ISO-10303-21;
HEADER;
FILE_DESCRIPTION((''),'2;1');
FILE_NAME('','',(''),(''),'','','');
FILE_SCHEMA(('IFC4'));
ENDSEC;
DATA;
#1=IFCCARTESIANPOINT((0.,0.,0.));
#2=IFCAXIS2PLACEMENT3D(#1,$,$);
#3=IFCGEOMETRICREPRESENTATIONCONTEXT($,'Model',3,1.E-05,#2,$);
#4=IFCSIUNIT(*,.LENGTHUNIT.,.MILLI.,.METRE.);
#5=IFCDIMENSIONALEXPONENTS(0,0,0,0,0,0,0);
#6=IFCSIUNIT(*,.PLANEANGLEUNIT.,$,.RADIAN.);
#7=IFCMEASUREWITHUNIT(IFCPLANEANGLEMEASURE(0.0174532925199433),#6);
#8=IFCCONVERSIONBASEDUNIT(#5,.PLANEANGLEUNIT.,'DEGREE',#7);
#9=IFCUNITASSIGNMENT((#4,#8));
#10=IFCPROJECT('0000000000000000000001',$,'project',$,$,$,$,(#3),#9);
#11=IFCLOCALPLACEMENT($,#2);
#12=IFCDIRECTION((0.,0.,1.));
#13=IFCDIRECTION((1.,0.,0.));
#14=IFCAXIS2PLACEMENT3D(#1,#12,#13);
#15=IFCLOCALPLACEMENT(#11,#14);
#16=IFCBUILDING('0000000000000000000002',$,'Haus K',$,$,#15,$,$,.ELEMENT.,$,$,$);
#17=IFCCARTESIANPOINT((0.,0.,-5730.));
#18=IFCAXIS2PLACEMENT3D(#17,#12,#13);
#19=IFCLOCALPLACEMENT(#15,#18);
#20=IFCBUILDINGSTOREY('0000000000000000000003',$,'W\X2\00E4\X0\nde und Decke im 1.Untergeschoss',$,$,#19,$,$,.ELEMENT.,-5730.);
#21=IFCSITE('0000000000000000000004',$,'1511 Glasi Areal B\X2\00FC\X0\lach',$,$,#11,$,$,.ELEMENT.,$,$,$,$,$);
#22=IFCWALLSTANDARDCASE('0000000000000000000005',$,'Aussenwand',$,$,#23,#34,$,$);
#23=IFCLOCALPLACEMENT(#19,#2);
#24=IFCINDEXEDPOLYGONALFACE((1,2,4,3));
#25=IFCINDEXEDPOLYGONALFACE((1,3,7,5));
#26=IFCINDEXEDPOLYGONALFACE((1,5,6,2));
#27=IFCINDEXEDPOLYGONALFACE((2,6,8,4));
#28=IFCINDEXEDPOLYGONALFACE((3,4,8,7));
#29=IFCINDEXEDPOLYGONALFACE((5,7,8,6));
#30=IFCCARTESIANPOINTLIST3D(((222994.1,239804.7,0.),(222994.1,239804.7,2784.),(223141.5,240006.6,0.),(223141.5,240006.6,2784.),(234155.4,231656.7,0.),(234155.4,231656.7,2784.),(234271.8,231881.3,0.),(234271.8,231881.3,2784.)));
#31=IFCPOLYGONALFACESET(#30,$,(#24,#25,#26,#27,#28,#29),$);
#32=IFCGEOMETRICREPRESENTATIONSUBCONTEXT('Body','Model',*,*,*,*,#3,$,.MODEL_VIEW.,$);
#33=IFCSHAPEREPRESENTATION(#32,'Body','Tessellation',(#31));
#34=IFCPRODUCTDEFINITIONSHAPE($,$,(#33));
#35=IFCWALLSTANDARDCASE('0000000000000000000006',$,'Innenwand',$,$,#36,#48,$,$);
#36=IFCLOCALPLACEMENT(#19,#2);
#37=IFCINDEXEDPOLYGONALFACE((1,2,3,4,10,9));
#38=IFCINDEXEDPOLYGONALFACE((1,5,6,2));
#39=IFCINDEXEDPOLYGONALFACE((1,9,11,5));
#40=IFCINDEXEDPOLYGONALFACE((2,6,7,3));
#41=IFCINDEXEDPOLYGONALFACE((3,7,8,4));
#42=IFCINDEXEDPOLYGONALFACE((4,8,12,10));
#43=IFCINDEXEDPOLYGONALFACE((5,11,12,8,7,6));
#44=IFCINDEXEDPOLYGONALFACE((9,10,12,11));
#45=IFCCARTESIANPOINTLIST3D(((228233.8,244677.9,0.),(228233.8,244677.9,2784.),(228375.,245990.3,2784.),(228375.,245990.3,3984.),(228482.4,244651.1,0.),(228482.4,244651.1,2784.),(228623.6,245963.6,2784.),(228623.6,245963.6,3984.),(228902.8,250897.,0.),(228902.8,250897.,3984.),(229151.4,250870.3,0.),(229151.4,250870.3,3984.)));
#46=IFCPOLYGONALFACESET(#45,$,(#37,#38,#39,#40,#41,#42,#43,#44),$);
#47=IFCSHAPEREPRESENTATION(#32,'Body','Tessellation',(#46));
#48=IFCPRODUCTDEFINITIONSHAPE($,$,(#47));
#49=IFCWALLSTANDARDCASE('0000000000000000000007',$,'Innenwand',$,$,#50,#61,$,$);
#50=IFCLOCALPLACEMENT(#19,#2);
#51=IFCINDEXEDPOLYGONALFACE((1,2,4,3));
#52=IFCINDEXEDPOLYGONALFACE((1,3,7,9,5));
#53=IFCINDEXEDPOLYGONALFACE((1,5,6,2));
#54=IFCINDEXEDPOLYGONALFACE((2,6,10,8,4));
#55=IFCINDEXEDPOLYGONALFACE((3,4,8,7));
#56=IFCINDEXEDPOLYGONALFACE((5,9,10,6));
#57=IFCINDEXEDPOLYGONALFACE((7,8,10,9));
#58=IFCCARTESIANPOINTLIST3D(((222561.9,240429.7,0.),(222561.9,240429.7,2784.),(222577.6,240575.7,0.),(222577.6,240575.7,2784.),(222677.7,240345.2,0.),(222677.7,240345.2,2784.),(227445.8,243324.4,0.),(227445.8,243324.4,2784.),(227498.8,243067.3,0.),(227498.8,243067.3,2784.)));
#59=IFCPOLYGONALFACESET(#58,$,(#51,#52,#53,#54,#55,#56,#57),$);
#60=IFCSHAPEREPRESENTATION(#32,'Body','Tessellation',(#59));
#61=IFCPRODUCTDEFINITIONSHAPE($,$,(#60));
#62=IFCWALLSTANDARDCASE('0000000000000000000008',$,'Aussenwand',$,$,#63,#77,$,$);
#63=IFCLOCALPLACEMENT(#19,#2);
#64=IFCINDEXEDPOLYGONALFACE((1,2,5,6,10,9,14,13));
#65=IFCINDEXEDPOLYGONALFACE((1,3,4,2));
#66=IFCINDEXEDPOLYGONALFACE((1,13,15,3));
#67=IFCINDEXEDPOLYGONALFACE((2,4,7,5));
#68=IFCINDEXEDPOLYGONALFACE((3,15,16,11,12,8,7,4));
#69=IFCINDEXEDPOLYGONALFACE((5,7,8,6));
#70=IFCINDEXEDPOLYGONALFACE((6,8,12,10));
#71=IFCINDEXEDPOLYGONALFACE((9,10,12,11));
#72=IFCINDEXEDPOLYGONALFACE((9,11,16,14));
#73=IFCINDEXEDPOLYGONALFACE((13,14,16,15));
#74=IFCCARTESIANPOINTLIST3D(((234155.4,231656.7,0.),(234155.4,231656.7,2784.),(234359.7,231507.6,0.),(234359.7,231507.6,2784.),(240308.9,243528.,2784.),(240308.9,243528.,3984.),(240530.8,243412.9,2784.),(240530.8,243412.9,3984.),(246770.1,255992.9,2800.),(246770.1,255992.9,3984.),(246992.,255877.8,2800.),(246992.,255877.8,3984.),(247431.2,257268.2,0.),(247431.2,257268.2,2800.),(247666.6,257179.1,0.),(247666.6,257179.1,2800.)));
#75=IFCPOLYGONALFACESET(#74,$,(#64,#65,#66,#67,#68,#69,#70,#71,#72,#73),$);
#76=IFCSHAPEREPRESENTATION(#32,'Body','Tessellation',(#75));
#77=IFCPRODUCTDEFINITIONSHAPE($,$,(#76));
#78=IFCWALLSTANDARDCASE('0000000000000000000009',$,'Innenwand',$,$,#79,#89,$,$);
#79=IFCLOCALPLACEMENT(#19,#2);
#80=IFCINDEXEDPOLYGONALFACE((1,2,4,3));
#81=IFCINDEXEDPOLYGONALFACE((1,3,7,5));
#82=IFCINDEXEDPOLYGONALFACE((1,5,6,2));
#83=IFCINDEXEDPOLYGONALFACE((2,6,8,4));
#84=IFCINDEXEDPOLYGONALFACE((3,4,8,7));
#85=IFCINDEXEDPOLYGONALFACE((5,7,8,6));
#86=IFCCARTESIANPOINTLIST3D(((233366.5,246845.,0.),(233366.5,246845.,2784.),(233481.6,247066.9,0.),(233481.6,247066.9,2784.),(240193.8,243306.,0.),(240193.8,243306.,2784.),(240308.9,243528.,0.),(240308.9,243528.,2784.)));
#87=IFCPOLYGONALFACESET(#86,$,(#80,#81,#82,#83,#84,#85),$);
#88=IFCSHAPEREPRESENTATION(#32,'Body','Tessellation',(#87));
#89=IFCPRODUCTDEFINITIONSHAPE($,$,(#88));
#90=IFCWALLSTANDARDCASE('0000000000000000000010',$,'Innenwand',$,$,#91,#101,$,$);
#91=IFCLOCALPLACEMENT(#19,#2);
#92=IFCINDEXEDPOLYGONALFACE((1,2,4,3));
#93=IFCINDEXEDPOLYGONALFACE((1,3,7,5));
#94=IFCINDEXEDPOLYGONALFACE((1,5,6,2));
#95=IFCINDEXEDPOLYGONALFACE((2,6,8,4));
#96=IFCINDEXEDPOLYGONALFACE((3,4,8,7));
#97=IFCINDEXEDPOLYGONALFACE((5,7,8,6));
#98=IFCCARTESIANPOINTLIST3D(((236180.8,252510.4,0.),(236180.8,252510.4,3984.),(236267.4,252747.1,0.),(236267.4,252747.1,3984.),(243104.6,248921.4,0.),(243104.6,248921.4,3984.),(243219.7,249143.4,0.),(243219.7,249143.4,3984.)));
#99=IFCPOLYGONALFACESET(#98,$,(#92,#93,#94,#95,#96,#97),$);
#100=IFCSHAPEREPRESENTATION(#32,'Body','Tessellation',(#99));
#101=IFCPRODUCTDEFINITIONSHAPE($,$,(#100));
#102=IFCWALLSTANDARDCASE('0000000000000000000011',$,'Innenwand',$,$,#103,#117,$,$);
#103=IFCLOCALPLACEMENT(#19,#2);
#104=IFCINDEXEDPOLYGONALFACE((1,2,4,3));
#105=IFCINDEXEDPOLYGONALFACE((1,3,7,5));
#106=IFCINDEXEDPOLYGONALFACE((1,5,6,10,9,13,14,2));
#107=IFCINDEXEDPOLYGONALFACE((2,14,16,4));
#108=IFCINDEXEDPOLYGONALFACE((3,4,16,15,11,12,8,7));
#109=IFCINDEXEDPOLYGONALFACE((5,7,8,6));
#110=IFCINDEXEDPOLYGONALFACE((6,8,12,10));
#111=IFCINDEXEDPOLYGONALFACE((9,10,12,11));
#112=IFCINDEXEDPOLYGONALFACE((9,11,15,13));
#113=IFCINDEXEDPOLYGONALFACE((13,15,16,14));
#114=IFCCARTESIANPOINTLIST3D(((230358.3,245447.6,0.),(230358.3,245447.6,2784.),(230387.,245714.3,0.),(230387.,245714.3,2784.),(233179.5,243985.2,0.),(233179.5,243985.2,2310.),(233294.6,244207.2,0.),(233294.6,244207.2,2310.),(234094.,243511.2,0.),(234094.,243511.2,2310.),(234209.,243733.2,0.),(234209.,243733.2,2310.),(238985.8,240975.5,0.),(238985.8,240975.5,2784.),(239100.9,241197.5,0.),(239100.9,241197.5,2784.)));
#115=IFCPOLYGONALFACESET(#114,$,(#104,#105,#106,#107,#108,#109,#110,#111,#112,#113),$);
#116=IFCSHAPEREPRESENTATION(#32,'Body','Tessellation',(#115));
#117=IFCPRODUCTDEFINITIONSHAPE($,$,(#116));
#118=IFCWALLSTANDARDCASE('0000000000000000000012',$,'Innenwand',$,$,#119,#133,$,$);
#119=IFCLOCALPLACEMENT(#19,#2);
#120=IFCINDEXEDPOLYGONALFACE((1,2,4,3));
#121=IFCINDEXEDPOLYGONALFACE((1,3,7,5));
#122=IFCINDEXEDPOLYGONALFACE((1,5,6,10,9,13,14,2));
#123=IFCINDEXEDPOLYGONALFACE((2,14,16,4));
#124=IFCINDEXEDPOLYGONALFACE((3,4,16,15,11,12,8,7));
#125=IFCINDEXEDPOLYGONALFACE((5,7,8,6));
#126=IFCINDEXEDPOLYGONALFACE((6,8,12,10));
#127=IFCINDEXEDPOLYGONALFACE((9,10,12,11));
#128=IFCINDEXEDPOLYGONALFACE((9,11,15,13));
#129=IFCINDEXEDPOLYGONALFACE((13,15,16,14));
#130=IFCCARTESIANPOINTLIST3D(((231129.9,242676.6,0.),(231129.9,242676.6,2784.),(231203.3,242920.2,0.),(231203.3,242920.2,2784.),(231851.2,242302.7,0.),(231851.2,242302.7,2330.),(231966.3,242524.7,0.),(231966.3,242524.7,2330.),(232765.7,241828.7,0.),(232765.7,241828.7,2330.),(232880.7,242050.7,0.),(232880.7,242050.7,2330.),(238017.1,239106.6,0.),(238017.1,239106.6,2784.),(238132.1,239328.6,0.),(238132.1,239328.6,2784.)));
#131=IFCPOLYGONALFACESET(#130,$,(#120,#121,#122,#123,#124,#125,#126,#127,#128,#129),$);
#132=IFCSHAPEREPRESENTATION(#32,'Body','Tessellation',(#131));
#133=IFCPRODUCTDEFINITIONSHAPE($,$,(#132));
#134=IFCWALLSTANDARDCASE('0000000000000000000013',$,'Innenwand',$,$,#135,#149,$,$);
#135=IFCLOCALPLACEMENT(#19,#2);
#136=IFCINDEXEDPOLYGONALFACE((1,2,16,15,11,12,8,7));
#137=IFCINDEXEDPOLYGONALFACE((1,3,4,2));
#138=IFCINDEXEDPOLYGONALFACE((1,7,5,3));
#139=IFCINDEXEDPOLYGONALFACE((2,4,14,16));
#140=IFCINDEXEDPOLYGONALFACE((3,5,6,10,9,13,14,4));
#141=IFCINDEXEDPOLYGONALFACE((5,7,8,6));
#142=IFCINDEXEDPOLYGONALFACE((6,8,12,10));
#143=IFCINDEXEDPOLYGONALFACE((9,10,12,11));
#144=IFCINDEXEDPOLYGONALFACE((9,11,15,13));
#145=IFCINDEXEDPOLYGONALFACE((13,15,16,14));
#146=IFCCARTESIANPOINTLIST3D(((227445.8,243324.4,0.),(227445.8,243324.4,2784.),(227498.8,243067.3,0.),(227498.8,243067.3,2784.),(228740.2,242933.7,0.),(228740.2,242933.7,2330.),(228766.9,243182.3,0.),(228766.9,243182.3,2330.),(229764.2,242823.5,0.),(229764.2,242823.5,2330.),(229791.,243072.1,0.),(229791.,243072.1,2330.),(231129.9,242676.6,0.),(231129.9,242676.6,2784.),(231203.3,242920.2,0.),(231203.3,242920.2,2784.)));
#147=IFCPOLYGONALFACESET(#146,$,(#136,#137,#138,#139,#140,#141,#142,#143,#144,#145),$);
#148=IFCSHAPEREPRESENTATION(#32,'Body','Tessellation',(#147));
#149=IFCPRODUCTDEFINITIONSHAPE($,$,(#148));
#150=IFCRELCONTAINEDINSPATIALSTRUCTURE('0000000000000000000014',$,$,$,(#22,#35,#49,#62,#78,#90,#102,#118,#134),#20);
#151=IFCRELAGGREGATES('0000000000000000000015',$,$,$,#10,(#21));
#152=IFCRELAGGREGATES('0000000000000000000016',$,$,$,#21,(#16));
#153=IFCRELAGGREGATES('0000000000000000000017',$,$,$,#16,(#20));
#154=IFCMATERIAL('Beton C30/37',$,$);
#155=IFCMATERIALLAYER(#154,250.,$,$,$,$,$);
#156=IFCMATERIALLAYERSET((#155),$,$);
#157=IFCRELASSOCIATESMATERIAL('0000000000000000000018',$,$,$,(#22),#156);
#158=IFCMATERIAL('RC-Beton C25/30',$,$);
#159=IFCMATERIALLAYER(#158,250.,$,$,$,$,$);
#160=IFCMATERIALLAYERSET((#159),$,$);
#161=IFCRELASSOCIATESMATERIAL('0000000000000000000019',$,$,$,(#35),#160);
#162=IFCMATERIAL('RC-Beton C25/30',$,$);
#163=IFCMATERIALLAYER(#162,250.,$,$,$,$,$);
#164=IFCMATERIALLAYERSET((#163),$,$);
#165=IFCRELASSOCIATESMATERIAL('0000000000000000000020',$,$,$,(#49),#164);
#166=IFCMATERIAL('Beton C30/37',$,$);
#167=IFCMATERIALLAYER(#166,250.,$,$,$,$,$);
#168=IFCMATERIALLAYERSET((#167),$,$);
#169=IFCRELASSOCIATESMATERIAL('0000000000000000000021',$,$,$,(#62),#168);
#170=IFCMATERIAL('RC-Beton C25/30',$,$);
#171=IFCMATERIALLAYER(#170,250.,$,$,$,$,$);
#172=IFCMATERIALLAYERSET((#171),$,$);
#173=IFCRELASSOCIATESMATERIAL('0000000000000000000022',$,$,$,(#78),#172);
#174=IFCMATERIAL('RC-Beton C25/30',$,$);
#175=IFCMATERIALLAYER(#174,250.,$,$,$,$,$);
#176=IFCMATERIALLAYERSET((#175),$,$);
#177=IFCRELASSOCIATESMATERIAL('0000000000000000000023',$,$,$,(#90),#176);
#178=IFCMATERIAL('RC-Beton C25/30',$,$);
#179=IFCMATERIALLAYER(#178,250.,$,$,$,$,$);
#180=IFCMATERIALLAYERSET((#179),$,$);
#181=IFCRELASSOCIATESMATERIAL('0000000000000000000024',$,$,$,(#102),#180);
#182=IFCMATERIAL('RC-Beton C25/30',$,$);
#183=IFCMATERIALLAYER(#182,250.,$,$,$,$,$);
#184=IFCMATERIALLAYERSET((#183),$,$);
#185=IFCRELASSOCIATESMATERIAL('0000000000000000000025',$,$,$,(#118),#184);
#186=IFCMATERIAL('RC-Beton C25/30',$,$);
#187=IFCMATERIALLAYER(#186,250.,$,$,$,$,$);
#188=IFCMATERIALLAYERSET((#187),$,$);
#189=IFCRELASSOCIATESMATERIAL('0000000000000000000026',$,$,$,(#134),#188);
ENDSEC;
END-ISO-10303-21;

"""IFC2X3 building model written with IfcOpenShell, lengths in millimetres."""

from ifc_helpers import new_model, entity, si_unit, converted_unit, frame, frame_2d, origin, origin_with_axes, place, context, subcontext, project, spatial, polyline, rectangle, outline, extrude, clip, bounded_halfspace, material, layer, layer_set, layer_usage, element, save


model = new_model("IFC2X3")

# Units and contexts
model_context = context("Model", 3, precision=1e-05, world=origin())
body_context = subcontext(model_context, "Body", "Model", "MODEL_VIEW")
ifc_project = project(units=[si_unit("LENGTHUNIT", "METRE", prefix="MILLI"), converted_unit("PLANEANGLEUNIT", "DEGREE", entity("IfcPlaneAngleMeasure", 0.0174532925199433), si_unit("PLANEANGLEUNIT", "RADIAN"), dimensions=[0, 0, 0, 0, 0, 0, 0])], contexts=[model_context])

# Site, building, storey
site_placement = place(None, origin())
site = spatial("IfcSite", under=ifc_project, at=site_placement, Name="1511 Glasi Areal Bülach", CompositionType="ELEMENT")
building_placement = place(site_placement, origin_with_axes())
building = spatial("IfcBuilding", under=site, at=building_placement, Name="Haus K", CompositionType="ELEMENT")
storey_placement = place(building_placement, frame((0.0, 0.0, -5730.0), z_axis=(0.0, 0.0, 1.0), x_axis=(1.0, 0.0, 0.0)))
storey = spatial("IfcBuildingStorey", under=building, at=storey_placement, Name="Wände und Decke im 1.Untergeschoss", CompositionType="ELEMENT", Elevation=-5730.0)

# Walls
ifc_material_1 = material(Name="Beton C30/37")
ifc_layer_1 = layer(ifc_material_1, 250.0)
ifc_layer_set_1 = layer_set([ifc_layer_1])
ifc_layer_usage_1 = layer_usage(ifc_layer_set_1, "AXIS2", "POSITIVE", 0.0)
wall_1_placement = place(storey_placement, frame((222994.1, 239804.7, 0.0), z_axis=(0.0, 0.0, 1.0), x_axis=(0.807681, -0.589619, 0.0)))
element("IfcWallStandardCase", 1, at=wall_1_placement, inside=storey, material=ifc_layer_usage_1, Name="Aussenwand", context=body_context, shape_type="SweptSolid", body=[
    extrude(outline(polyline([(0.0, 0.0), (13819.0, 0.0), (13780.6, 250.0), (0.0, 250.0), (0.0, 0.0)])), origin_with_axes(), (0.0, 0.0, 1.0), 2784.0),
])
ifc_material_2 = material(Name="RC-Beton C25/30")
ifc_layer_2 = layer(ifc_material_2, 250.0)
ifc_layer_set_2 = layer_set([ifc_layer_2])
ifc_layer_usage_2 = layer_usage(ifc_layer_set_2, "AXIS2", "POSITIVE", 0.0)
wall_2_placement = place(storey_placement, frame((228902.8, 250897.0, 0.0), z_axis=(0.0, 0.0, 1.0), x_axis=(-0.106958, -0.994264, 0.0)))
element("IfcWallStandardCase", 2, at=wall_2_placement, inside=storey, material=ifc_layer_usage_2, Name="Innenwand", context=body_context, shape_type="Clipping", body=[
    clip(clip(extrude(rectangle(XDim=6255.0, YDim=250.0, at=frame_2d((3127.5, 125.0), x_axis=(1.0, 0.0))), origin_with_axes(), (0.0, 0.0, 1.0), 3984.0), bounded_halfspace(frame((6255.0, 0.0, 2784.0), z_axis=(0.0, 0.0, -1.0), x_axis=(0.0, 1.0, 0.0)), True, origin(), polyline([(6255.0, 0.0), (6255.0, 250.0), (4935.0, 250.0), (4935.0, 0.0), (6255.0, 0.0)]))), bounded_halfspace(frame((4935.0, 0.0, 3984.0), z_axis=(0.0, 0.0, -1.0), x_axis=(0.0, 1.0, 0.0)), True, origin(), polyline([(4935.0, 0.0), (4935.0, 250.0), (0.0, 250.0), (0.0, 0.0), (4935.0, 0.0)]))),
])
ifc_material_3 = material(Name="RC-Beton C25/30")
ifc_layer_3 = layer(ifc_material_3, 250.0)
ifc_layer_set_3 = layer_set([ifc_layer_3])
ifc_layer_usage_3 = layer_usage(ifc_layer_set_3, "AXIS2", "POSITIVE", 0.0)
wall_3_placement = place(storey_placement, frame((227445.8, 243324.4, 0.0), z_axis=(0.0, 0.0, 1.0), x_axis=(-0.870785, -0.491664, 0.0)))
element("IfcWallStandardCase", 3, at=wall_3_placement, inside=storey, material=ifc_layer_usage_3, Name="Innenwand", context=body_context, shape_type="SweptSolid", body=[
    extrude(outline(polyline([(0.0, 0.0), (5590.5, 0.0), (5676.0, 119.4), (5616.7, 250.0), (80.2, 250.0), (0.0, 0.0)])), origin_with_axes(), (0.0, 0.0, 1.0), 2784.0),
])
ifc_material_4 = material(Name="Beton C30/37")
ifc_layer_4 = layer(ifc_material_4, 250.0)
ifc_layer_set_4 = layer_set([ifc_layer_4])
ifc_layer_usage_4 = layer_usage(ifc_layer_set_4, "AXIS2", "POSITIVE", 0.0)
wall_4_placement = place(storey_placement, frame((234359.7, 231507.6, 0.0), z_axis=(0.0, 0.0, 1.0), x_axis=(0.4602, 0.887815, 0.0)))
element("IfcWallStandardCase", 4, at=wall_4_placement, inside=storey, material=ifc_layer_usage_4, Name="Aussenwand", context=body_context, shape_type="Clipping", body=[
    clip(clip(clip(extrude(outline(polyline([(0.0, 0.0), (28915.4, 0.0), (28886.1, 250.0), (38.4, 250.0), (0.0, 0.0)])), origin_with_axes(), (0.0, 0.0, 1.0), 3984.0), bounded_halfspace(frame((13409.7, 250.0, 2784.0), z_axis=(0.0, 0.0, -1.0), x_axis=(-1.0, 0.0, 0.0)), True, origin(), polyline([(13409.7, 250.0), (38.4, 250.0), (0.0, 0.0), (13409.7, 0.0), (13409.7, 250.0)]))), bounded_halfspace(frame((27449.7, 0.0, 2800.0), z_axis=(0.0, 0.0, -1.0), x_axis=(1.0, 0.0, 0.0)), True, origin(), polyline([(27449.7, 0.0), (28915.4, 0.0), (28886.1, 250.0), (27449.7, 250.0), (27449.7, 0.0)]))), bounded_halfspace(frame((27449.7, 0.0, 3984.0), z_axis=(0.0, 0.0, -1.0), x_axis=(0.0, 1.0, 0.0)), True, origin(), polyline([(27449.7, 0.0), (27449.7, 250.0), (13409.7, 250.0), (13409.7, 0.0), (27449.7, 0.0)]))),
])
ifc_material_5 = material(Name="RC-Beton C25/30")
ifc_layer_5 = layer(ifc_material_5, 250.0)
ifc_layer_set_5 = layer_set([ifc_layer_5])
ifc_layer_usage_5 = layer_usage(ifc_layer_set_5, "AXIS2", "POSITIVE", 0.0)
wall_5_placement = place(storey_placement, frame((233366.5, 246845.0, 0.0), z_axis=(0.0, 0.0, 1.0), x_axis=(0.887815, -0.4602, 0.0)))
element("IfcWallStandardCase", 5, at=wall_5_placement, inside=storey, material=ifc_layer_usage_5, Name="Innenwand", context=body_context, shape_type="SweptSolid", body=[
    extrude(rectangle(XDim=7690.0, YDim=250.0, at=frame_2d((3845.0, 125.0), x_axis=(1.0, 0.0))), origin_with_axes(), (0.0, 0.0, 1.0), 2784.0),
])
ifc_material_6 = material(Name="RC-Beton C25/30")
ifc_layer_6 = layer(ifc_material_6, 250.0)
ifc_layer_set_6 = layer_set([ifc_layer_6])
ifc_layer_usage_6 = layer_usage(ifc_layer_set_6, "AXIS2", "POSITIVE", 0.0)
wall_6_placement = place(storey_placement, frame((243219.7, 249143.4, 0.0), z_axis=(0.0, 0.0, 1.0), x_axis=(-0.887815, 0.4602, 0.0)))
element("IfcWallStandardCase", 6, at=wall_6_placement, inside=storey, material=ifc_layer_usage_6, Name="Innenwand", context=body_context, shape_type="SweptSolid", body=[
    extrude(outline(polyline([(0.0, 0.0), (7830.8, 0.0), (7798.7, 250.0), (0.0, 250.0), (0.0, 0.0)])), origin_with_axes(), (0.0, 0.0, 1.0), 3984.0),
])

# Walls, openings
ifc_material_7 = material(Name="RC-Beton C25/30")
ifc_layer_7 = layer(ifc_material_7, 250.0)
ifc_layer_set_7 = layer_set([ifc_layer_7])
ifc_layer_usage_7 = layer_usage(ifc_layer_set_7, "AXIS2", "POSITIVE", 0.0)
wall_7_placement = place(storey_placement, frame((239100.9, 241197.5, 0.0), z_axis=(0.0, 0.0, 1.0), x_axis=(-0.887815, 0.4602, 0.0)))
wall_7 = element("IfcWallStandardCase", 7, at=wall_7_placement, inside=storey, material=ifc_layer_usage_7, Name="Innenwand", context=body_context, shape_type="SweptSolid", body=[
    extrude(outline(polyline([(0.0, 0.0), (9814.9, 0.0), (9717.7, 250.0), (0.0, 250.0), (0.0, 0.0)])), origin_with_axes(), (0.0, 0.0, 1.0), 2784.0),
])
opening_1_placement = place(wall_7_placement, frame((5510.0, 0.0, 0.0), z_axis=(0.0, 1.0, 0.0), x_axis=(0.0, 0.0, 1.0)))
element("IfcOpeningElement", 8, at=opening_1_placement, cuts=wall_7, ObjectType="Opening", context=body_context, shape_type="SweptSolid", body=[
    extrude(rectangle(XDim=2310.0, YDim=1030.0, at=frame_2d((1155.0, 515.0), x_axis=(1.0, 0.0))), origin_with_axes(), (0.0, 0.0, 1.0), 250.0),
])
ifc_material_8 = material(Name="RC-Beton C25/30")
ifc_layer_8 = layer(ifc_material_8, 250.0)
ifc_layer_set_8 = layer_set([ifc_layer_8])
ifc_layer_usage_8 = layer_usage(ifc_layer_set_8, "AXIS2", "POSITIVE", 0.0)
wall_8_placement = place(storey_placement, frame((238132.1, 239328.6, 0.0), z_axis=(0.0, 0.0, 1.0), x_axis=(-0.887815, 0.4602, 0.0)))
wall_8 = element("IfcWallStandardCase", 9, at=wall_8_placement, inside=storey, material=ifc_layer_usage_8, Name="Innenwand", context=body_context, shape_type="SweptSolid", body=[
    extrude(outline(polyline([(0.0, 0.0), (7804.4, 0.0), (7757.5, 250.0), (0.0, 250.0), (0.0, 0.0)])), origin_with_axes(), (0.0, 0.0, 1.0), 2784.0),
])
opening_2_placement = place(wall_8_placement, frame((5915.0, 0.0, 0.0), z_axis=(0.0, 1.0, 0.0), x_axis=(0.0, 0.0, 1.0)))
element("IfcOpeningElement", 10, at=opening_2_placement, cuts=wall_8, ObjectType="Opening", context=body_context, shape_type="SweptSolid", body=[
    extrude(rectangle(XDim=2330.0, YDim=1030.0, at=frame_2d((1165.0, 515.0), x_axis=(1.0, 0.0))), origin_with_axes(), (0.0, 0.0, 1.0), 250.0),
])
ifc_material_9 = material(Name="RC-Beton C25/30")
ifc_layer_9 = layer(ifc_material_9, 250.0)
ifc_layer_set_9 = layer_set([ifc_layer_9])
ifc_layer_usage_9 = layer_usage(ifc_layer_set_9, "AXIS2", "POSITIVE", 0.0)
wall_9_placement = place(storey_placement, frame((231203.3, 242920.2, 0.0), z_axis=(0.0, 0.0, 1.0), x_axis=(-0.994264, 0.106958, 0.0)))
wall_9 = element("IfcWallStandardCase", 11, at=wall_9_placement, inside=storey, material=ifc_layer_usage_9, Name="Innenwand", context=body_context, shape_type="SweptSolid", body=[
    extrude(outline(polyline([(0.0, 0.0), (3779.2, 0.0), (3699.0, 250.0), (46.9, 250.0), (0.0, 0.0)])), origin_with_axes(), (0.0, 0.0, 1.0), 2784.0),
])
opening_3_placement = place(wall_9_placement, frame((1420.4, 0.0, 0.0), z_axis=(0.0, 1.0, 0.0), x_axis=(0.0, 0.0, 1.0)))
element("IfcOpeningElement", 12, at=opening_3_placement, cuts=wall_9, ObjectType="Opening", context=body_context, shape_type="SweptSolid", body=[
    extrude(rectangle(XDim=2330.0, YDim=1030.0, at=frame_2d((1165.0, 515.0), x_axis=(1.0, 0.0))), origin_with_axes(), (0.0, 0.0, 1.0), 250.0),
])

save(model, "model.ifc")
